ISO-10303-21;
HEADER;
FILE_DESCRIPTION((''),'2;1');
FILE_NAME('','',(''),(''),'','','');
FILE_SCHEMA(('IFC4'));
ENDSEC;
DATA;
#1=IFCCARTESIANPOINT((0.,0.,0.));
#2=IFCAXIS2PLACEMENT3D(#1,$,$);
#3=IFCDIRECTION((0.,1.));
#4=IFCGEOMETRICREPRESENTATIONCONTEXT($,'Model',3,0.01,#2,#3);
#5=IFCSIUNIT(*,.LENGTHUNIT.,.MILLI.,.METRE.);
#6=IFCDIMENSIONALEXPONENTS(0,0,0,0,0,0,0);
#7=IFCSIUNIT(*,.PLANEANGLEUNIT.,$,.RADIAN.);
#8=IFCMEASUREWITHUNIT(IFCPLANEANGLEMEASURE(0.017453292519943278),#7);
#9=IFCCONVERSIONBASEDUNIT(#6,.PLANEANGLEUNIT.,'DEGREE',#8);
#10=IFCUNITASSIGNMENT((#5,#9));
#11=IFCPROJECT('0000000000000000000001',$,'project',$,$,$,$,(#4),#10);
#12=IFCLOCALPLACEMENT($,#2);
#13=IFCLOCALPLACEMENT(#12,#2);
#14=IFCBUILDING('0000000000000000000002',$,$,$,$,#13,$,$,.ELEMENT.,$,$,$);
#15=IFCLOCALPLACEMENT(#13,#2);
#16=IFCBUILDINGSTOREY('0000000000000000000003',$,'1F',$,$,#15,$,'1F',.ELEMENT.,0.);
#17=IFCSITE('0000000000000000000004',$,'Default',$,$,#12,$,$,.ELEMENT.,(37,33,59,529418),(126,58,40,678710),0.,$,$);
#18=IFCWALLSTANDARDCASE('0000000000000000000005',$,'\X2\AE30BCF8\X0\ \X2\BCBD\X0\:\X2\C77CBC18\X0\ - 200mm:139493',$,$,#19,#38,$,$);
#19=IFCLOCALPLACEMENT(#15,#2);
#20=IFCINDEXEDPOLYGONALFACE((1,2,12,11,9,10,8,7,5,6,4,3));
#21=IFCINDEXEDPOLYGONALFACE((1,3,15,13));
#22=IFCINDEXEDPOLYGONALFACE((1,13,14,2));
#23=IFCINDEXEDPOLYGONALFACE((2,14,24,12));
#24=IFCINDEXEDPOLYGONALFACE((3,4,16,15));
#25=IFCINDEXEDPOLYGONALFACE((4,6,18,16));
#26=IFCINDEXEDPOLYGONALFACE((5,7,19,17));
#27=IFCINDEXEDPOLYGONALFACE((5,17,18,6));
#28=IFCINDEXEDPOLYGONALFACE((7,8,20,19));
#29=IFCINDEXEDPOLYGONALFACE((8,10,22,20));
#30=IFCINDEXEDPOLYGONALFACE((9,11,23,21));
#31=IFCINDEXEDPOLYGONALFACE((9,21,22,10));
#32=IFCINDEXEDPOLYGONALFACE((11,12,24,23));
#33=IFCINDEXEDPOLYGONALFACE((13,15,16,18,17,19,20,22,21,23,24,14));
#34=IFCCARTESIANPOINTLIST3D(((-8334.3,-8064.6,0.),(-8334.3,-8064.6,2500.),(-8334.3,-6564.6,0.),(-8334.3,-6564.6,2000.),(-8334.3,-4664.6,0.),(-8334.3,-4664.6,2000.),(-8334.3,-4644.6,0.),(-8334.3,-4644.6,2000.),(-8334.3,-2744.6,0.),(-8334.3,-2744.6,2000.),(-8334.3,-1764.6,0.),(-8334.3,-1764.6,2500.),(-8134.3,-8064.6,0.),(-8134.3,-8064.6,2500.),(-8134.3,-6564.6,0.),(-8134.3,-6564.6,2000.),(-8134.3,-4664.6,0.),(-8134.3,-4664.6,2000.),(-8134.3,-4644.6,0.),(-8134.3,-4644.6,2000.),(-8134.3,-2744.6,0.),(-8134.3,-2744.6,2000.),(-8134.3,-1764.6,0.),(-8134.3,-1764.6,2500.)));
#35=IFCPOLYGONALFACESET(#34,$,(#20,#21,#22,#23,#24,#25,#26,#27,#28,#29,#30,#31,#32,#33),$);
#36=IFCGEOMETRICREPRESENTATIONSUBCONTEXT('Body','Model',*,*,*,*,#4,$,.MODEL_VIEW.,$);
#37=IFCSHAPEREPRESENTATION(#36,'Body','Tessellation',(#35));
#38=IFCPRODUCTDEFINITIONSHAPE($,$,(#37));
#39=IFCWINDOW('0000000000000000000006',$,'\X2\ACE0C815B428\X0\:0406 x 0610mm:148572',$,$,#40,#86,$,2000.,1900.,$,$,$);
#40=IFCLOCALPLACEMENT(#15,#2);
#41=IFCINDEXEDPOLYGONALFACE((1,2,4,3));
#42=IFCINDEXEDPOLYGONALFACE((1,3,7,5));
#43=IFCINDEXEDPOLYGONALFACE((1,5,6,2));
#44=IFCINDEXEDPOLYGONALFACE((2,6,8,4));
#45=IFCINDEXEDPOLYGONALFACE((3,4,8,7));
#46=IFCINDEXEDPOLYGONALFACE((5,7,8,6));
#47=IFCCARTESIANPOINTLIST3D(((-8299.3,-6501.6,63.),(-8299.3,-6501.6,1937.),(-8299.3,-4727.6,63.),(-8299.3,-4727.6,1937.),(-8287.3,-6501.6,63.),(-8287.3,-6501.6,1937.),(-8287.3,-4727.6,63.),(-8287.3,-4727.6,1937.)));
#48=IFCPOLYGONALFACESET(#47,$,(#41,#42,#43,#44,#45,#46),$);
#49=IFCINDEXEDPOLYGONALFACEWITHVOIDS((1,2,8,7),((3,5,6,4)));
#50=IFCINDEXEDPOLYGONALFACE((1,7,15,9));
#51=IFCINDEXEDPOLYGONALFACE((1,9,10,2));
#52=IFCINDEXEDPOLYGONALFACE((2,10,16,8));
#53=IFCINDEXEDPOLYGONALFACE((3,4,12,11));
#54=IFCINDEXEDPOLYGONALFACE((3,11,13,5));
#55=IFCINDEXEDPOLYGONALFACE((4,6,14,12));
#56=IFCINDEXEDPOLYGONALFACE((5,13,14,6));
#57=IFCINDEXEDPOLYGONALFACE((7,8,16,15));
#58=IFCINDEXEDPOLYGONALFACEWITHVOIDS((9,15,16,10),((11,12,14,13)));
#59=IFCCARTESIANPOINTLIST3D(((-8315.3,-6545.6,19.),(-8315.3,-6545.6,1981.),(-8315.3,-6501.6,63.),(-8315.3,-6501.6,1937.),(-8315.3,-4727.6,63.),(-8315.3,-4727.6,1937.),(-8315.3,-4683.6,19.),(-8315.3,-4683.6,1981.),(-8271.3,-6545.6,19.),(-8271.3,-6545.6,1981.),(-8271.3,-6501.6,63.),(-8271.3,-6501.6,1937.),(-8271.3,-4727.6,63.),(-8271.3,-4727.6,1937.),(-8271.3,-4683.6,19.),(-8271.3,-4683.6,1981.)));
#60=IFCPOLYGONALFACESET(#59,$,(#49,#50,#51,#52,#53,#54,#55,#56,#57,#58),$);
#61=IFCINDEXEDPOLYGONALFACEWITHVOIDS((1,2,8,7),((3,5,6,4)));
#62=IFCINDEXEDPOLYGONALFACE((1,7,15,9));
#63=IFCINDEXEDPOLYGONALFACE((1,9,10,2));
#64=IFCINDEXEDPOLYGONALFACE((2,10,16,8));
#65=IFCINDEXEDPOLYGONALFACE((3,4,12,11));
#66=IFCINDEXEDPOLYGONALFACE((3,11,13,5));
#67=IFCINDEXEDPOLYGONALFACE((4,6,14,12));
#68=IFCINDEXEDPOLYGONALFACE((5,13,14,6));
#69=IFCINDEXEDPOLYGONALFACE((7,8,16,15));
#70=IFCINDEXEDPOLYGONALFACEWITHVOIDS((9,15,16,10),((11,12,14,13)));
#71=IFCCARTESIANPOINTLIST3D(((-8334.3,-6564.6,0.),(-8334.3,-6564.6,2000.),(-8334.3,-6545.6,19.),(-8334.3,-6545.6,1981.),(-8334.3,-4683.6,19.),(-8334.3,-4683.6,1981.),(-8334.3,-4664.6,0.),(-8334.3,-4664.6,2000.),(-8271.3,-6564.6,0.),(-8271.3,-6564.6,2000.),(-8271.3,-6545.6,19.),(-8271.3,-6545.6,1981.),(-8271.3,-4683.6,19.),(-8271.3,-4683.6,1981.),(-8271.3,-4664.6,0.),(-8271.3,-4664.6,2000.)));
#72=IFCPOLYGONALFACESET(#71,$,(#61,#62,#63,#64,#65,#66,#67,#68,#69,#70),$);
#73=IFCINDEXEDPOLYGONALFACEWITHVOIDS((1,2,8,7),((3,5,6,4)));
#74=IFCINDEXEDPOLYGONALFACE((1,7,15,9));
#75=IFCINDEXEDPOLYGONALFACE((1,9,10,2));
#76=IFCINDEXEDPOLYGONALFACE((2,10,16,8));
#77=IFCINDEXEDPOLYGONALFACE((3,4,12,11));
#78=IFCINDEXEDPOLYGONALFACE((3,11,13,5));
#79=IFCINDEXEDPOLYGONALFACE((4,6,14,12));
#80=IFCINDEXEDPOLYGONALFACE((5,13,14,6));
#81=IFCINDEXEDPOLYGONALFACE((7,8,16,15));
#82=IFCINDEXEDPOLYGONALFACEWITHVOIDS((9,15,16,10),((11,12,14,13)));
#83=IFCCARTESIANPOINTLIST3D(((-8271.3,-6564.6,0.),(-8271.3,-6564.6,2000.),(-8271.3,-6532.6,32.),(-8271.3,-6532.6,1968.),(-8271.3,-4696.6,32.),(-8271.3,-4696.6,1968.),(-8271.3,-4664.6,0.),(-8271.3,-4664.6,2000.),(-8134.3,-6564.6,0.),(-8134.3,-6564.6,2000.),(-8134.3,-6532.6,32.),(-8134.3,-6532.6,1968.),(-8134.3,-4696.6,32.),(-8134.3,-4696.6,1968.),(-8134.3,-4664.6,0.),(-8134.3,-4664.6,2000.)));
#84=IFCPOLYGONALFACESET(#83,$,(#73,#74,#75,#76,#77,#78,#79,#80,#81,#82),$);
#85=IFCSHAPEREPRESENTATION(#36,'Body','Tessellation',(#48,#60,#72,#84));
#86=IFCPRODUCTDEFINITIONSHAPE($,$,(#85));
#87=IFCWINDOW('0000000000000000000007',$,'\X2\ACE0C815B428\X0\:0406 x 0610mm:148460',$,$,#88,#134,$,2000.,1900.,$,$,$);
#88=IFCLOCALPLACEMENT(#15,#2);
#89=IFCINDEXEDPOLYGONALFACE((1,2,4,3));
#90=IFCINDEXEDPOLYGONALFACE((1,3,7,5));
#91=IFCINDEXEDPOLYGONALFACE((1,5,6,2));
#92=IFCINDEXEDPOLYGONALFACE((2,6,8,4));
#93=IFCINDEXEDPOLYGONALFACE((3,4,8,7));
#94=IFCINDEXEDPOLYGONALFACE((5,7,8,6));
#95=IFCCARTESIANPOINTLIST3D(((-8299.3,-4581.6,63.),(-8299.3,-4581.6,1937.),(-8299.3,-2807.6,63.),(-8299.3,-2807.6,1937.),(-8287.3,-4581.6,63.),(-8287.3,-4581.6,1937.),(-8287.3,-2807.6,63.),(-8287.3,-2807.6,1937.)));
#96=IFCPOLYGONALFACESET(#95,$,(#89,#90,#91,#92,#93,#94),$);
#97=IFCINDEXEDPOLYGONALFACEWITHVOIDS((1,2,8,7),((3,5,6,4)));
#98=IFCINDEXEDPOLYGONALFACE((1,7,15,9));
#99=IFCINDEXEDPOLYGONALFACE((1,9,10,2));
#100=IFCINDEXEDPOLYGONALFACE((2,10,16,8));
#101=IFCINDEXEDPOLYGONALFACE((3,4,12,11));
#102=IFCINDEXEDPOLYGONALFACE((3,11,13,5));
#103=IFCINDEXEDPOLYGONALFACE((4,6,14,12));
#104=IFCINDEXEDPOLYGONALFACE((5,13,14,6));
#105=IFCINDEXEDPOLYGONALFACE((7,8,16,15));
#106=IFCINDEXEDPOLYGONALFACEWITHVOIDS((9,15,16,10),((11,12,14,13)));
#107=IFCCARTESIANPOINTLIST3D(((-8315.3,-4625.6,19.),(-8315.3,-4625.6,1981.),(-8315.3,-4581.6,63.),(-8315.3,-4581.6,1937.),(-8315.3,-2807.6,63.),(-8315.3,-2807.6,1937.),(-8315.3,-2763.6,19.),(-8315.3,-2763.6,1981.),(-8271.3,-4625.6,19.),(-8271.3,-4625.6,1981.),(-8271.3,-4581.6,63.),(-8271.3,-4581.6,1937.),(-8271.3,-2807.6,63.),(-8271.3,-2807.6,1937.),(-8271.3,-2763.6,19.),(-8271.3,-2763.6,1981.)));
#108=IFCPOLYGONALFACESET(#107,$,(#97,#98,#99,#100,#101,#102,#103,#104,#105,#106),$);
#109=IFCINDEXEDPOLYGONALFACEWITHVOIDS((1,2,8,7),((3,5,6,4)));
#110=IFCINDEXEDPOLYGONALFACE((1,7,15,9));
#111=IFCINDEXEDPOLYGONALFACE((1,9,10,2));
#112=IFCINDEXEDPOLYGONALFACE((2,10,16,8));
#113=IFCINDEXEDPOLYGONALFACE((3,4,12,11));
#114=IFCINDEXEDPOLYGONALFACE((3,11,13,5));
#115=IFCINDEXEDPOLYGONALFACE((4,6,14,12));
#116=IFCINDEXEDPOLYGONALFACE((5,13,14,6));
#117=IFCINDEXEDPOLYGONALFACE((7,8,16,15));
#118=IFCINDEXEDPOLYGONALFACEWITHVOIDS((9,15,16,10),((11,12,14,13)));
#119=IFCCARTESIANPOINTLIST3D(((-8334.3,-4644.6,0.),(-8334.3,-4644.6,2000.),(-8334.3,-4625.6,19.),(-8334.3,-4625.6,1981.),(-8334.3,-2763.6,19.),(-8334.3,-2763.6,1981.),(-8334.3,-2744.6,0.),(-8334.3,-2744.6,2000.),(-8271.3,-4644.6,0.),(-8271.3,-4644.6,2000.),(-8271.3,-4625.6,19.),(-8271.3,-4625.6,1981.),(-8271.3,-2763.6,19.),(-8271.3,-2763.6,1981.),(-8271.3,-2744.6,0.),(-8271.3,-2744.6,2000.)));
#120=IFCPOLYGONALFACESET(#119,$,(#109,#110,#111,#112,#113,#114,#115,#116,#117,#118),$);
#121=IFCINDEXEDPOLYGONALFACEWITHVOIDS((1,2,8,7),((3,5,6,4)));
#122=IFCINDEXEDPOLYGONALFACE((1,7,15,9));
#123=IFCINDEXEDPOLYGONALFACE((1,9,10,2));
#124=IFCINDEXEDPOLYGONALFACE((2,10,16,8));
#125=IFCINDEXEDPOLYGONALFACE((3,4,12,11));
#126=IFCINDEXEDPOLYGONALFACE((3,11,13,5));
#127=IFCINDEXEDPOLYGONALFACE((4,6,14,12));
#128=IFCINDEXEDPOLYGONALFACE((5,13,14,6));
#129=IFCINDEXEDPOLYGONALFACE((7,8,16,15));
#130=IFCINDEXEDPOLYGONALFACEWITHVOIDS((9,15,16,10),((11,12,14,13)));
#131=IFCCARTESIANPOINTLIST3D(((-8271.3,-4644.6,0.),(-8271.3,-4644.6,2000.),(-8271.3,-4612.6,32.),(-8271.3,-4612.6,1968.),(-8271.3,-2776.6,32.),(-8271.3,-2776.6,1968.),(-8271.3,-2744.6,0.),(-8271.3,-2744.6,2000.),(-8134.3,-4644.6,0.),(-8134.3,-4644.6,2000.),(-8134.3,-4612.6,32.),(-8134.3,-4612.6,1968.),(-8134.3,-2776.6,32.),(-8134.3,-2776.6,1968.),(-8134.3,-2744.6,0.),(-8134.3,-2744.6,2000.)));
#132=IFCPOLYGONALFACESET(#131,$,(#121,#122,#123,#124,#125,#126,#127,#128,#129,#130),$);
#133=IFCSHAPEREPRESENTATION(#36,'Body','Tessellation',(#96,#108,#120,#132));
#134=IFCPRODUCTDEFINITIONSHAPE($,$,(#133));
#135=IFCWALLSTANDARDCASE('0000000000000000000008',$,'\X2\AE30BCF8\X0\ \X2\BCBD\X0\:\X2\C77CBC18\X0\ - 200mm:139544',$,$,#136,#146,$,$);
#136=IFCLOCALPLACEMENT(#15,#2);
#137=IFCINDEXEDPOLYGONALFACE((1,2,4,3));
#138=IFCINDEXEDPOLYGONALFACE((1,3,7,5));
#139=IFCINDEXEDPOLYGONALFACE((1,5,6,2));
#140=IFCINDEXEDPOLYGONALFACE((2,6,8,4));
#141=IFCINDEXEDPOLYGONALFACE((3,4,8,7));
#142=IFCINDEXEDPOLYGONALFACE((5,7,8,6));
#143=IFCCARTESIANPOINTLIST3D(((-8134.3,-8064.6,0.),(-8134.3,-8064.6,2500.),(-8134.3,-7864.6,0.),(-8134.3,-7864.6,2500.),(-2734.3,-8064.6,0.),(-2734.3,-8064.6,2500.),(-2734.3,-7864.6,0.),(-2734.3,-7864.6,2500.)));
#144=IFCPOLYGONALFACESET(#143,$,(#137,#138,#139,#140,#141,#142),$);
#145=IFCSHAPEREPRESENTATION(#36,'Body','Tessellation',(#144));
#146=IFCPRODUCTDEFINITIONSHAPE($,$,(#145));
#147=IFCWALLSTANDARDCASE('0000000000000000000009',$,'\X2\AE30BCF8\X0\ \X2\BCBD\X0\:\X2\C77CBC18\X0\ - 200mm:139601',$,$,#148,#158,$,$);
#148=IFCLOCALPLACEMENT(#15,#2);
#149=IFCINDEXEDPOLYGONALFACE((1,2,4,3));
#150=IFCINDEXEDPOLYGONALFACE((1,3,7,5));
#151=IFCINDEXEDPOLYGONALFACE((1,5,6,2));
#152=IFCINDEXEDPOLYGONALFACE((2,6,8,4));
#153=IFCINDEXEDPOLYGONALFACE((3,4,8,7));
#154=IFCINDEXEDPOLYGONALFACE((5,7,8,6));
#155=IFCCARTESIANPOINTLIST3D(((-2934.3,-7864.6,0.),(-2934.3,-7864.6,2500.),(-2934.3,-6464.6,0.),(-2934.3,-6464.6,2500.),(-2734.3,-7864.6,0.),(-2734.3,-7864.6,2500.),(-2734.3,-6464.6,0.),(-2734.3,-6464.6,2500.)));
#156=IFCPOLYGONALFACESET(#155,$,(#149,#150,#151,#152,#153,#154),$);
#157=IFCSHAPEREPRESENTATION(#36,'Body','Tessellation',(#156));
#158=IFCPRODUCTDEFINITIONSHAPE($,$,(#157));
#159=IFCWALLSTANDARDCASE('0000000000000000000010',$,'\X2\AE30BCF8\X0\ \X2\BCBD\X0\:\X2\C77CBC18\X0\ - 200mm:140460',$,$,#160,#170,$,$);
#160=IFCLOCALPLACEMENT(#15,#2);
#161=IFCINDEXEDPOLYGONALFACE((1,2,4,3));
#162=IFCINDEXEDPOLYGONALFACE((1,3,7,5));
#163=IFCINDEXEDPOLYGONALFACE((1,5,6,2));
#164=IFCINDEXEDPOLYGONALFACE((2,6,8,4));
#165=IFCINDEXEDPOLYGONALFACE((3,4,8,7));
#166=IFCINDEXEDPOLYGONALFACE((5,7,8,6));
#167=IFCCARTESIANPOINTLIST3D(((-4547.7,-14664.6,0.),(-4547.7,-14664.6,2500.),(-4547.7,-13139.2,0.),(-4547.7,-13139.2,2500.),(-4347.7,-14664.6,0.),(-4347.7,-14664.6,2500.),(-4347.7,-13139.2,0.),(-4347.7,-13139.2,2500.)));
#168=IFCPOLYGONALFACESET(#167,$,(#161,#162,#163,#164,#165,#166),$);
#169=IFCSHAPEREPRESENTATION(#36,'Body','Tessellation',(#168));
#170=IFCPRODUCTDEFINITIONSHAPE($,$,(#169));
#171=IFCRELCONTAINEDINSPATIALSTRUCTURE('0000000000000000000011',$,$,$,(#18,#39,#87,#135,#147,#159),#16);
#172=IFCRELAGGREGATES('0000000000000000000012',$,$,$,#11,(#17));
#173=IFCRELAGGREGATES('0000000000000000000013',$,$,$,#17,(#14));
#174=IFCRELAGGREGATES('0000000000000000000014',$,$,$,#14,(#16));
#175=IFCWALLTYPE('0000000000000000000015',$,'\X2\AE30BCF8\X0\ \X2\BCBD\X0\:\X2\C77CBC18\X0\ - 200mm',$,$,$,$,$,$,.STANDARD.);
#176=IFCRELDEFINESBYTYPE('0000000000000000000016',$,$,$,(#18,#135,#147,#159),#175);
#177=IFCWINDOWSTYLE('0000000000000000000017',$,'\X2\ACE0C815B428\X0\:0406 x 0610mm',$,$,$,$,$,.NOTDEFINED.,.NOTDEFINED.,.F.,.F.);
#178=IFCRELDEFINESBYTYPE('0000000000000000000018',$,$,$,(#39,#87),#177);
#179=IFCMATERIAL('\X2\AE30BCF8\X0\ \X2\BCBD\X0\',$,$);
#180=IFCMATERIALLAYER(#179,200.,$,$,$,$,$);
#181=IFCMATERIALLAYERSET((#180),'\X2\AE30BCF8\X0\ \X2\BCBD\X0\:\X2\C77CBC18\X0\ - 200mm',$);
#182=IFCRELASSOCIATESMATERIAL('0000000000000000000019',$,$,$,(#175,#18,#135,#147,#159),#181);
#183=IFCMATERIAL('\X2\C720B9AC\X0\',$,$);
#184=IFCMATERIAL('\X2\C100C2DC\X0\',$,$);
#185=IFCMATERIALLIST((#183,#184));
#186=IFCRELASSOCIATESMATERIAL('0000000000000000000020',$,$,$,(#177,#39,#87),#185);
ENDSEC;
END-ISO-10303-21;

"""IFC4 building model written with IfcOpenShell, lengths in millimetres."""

from ifc_helpers import new_model, entity, si_unit, converted_unit, direction, frame, frame_2d, origin, place, context, subcontext, project, spatial, polyline, rectangle, outline, extrude, source, transform, mapped, material, material_list, layer, layer_set, layer_usage, type_object, type_shapes, element, fill, save


model = new_model("IFC4")

# Units and contexts
model_context = context("Model", 3, precision=0.01, world=origin(), true_north=direction((0.0, 1.0)))
body_context = subcontext(model_context, "Body", "Model", "MODEL_VIEW")
ifc_project = project(units=[si_unit("LENGTHUNIT", "METRE", prefix="MILLI"), converted_unit("PLANEANGLEUNIT", "DEGREE", entity("IfcPlaneAngleMeasure", 0.017453292519943278), si_unit("PLANEANGLEUNIT", "RADIAN"), dimensions=[0, 0, 0, 0, 0, 0, 0])], contexts=[model_context])

# Site, building, storey
site_placement = place(None, origin())
site = spatial("IfcSite", under=ifc_project, at=site_placement, Name="Default", CompositionType="ELEMENT", RefLatitude=(37, 33, 59, 529418), RefLongitude=(126, 58, 40, 678710), RefElevation=0.0)
building_placement = place(site_placement, origin())
building = spatial("IfcBuilding", under=site, at=building_placement, CompositionType="ELEMENT")
storey_placement = place(building_placement, origin())
storey = spatial("IfcBuildingStorey", under=building, at=storey_placement, Name="1F", LongName="1F", CompositionType="ELEMENT", Elevation=0.0)

# Shared definitions
ifc_material_1 = material(Name="기본 벽")
ifc_layer_1 = layer(ifc_material_1, 200.0)
ifc_layer_set_1 = layer_set([ifc_layer_1], Name="기본 벽:일반 - 200mm")
wall_type = type_object("IfcWallType", Name="기본 벽:일반 - 200mm", PredefinedType="STANDARD", material=ifc_layer_set_1)
ifc_material_2 = material(Name="유리")
ifc_material_3 = material(Name="섀시")
ifc_material_list = material_list([ifc_material_2, ifc_material_3])
window_style = type_object("IfcWindowStyle", Name="고정됨:0406 x 0610mm", ConstructionType="NOTDEFINED", OperationType="NOTDEFINED", ParameterTakesPrecedence=False, Sizeable=False, material=ifc_material_list)
shared_shape = source(origin(), body_context, "Body", "SweptSolid", [
    extrude(rectangle(XDim=12.0, YDim=1774.0, at=frame_2d((0.0, 0.0), x_axis=(1.0, 0.0))), frame((950.0, 159.0, 63.0), z_axis=(0.0, 0.0, 1.0), x_axis=(0.0, -1.0, 0.0)), (0.0, 0.0, 1.0), 1874.0),
    extrude(outline(polyline([(-931.0, -981.0), (931.0, -981.0), (931.0, 981.0), (-931.0, 981.0), (-931.0, -981.0)]), holes=[polyline([(-887.0, -937.0), (-887.0, 937.0), (887.0, 937.0), (887.0, -937.0), (-887.0, -937.0)])]), frame((950.0, 137.0, 1000.0), z_axis=(0.0, 1.0, 0.0), x_axis=(1.0, 0.0, 0.0)), (0.0, 0.0, 1.0), 44.0),
    extrude(outline(polyline([(-950.0, -1000.0), (950.0, -1000.0), (950.0, 1000.0), (-950.0, 1000.0), (-950.0, -1000.0)]), holes=[polyline([(-931.0, -981.0), (-931.0, 981.0), (931.0, 981.0), (931.0, -981.0), (-931.0, -981.0)])]), frame((950.0, 137.0, 1000.0), z_axis=(0.0, 1.0, 0.0), x_axis=(1.0, 0.0, 0.0)), (0.0, 0.0, 1.0), 63.0),
    extrude(outline(polyline([(-950.0, -1000.0), (950.0, -1000.0), (950.0, 1000.0), (-950.0, 1000.0), (-950.0, -1000.0)]), holes=[polyline([(-918.0, -968.0), (-918.0, 968.0), (918.0, 968.0), (918.0, -968.0), (-918.0, -968.0)])]), frame((950.0, 0.0, 1000.0), z_axis=(0.0, 1.0, 0.0), x_axis=(1.0, 0.0, 0.0)), (0.0, 0.0, 1.0), 137.0),
])
type_shapes(window_style, [shared_shape])

# Wall, openings, windows
ifc_layer_usage_1 = layer_usage(ifc_layer_set_1, "AXIS2", "NEGATIVE", 100.0)
wall_1_placement = place(storey_placement, frame((-8234.3, -1764.6, 0.0), z_axis=(0.0, 0.0, 1.0), x_axis=(0.0, -1.0, 0.0)))
wall_1 = element("IfcWallStandardCase", 1, at=wall_1_placement, inside=storey, type_object=wall_type, material=ifc_layer_usage_1, Name="기본 벽:일반 - 200mm:139493", context=body_context, shape_type="SweptSolid", body=[
    extrude(rectangle(XDim=6300.0, YDim=200.0, at=frame_2d((3150.0, 0.0), x_axis=(-1.0, 0.0))), origin(), (0.0, 0.0, 1.0), 2500.0),
])
opening_1_placement = place(wall_1_placement, frame((4800.0, 100.0, 0.0)))
opening_1 = element("IfcOpeningElement", 2, at=opening_1_placement, cuts=wall_1, ObjectType="Opening", context=body_context, shape_type="SweptSolid", body=[
    extrude(rectangle(XDim=2000.0, YDim=1900.0, at=frame_2d((1000.0, 950.0), x_axis=(1.0, 0.0))), frame((0.0, 0.0, 0.0), z_axis=(0.0, -1.0, 0.0), x_axis=(0.0, 0.0, 1.0)), (0.0, 0.0, 1.0), 200.0),
])
opening_2_placement = place(wall_1_placement, frame((2880.0, 100.0, 0.0)))
opening_2 = element("IfcOpeningElement", 3, at=opening_2_placement, cuts=wall_1, ObjectType="Opening", context=body_context, shape_type="SweptSolid", body=[
    extrude(rectangle(XDim=2000.0, YDim=1900.0, at=frame_2d((1000.0, 950.0), x_axis=(1.0, 0.0))), frame((0.0, 0.0, 0.0), z_axis=(0.0, -1.0, 0.0), x_axis=(0.0, 0.0, 1.0)), (0.0, 0.0, 1.0), 200.0),
])
window_1_placement = place(opening_1_placement, frame((0.0, 0.0, 0.0), z_axis=(0.0, 0.0, 1.0), x_axis=(-1.0, 0.0, 0.0)))
window_1 = element("IfcWindow", 4, at=window_1_placement, inside=storey, type_object=window_style, material=ifc_material_list, Name="고정됨:0406 x 0610mm:148572", OverallHeight=2000.0, OverallWidth=1900.0, context=body_context, shape_type="MappedRepresentation", body=[
    mapped(shared_shape, transform((0.0, 0.0, 0.0), scale=1.0)),
])
fill(opening_1, window_1)
window_2_placement = place(opening_2_placement, frame((0.0, 0.0, 0.0), z_axis=(0.0, 0.0, 1.0), x_axis=(-1.0, 0.0, 0.0)))
window_2 = element("IfcWindow", 5, at=window_2_placement, inside=storey, type_object=window_style, material=ifc_material_list, Name="고정됨:0406 x 0610mm:148460", OverallHeight=2000.0, OverallWidth=1900.0, context=body_context, shape_type="MappedRepresentation", body=[
    mapped(shared_shape, transform((0.0, 0.0, 0.0), scale=1.0)),
])
fill(opening_2, window_2)

# Walls
ifc_layer_usage_2 = layer_usage(ifc_layer_set_1, "AXIS2", "NEGATIVE", 100.0)
wall_2_placement = place(storey_placement, frame((-8134.3, -7964.6, 0.0)))
element("IfcWallStandardCase", 6, at=wall_2_placement, inside=storey, type_object=wall_type, material=ifc_layer_usage_2, Name="기본 벽:일반 - 200mm:139544", context=body_context, shape_type="SweptSolid", body=[
    extrude(rectangle(XDim=5400.0, YDim=200.0, at=frame_2d((2700.0, 0.0), x_axis=(-1.0, 0.0))), origin(), (0.0, 0.0, 1.0), 2500.0),
])
ifc_layer_usage_3 = layer_usage(ifc_layer_set_1, "AXIS2", "NEGATIVE", 100.0)
wall_3_placement = place(storey_placement, frame((-2834.3, -7864.6, 0.0), z_axis=(0.0, 0.0, 1.0), x_axis=(0.0, 1.0, 0.0)))
element("IfcWallStandardCase", 7, at=wall_3_placement, inside=storey, type_object=wall_type, material=ifc_layer_usage_3, Name="기본 벽:일반 - 200mm:139601", context=body_context, shape_type="SweptSolid", body=[
    extrude(rectangle(XDim=1400.0, YDim=200.0, at=frame_2d((700.0, 0.0), x_axis=(-1.0, 0.0))), origin(), (0.0, 0.0, 1.0), 2500.0),
])
ifc_layer_usage_4 = layer_usage(ifc_layer_set_1, "AXIS2", "NEGATIVE", 100.0)
wall_4_placement = place(storey_placement, frame((-4447.7, -13139.2, 0.0), z_axis=(0.0, 0.0, 1.0), x_axis=(0.0, -1.0, 0.0)))
element("IfcWallStandardCase", 8, at=wall_4_placement, inside=storey, type_object=wall_type, material=ifc_layer_usage_4, Name="기본 벽:일반 - 200mm:140460", context=body_context, shape_type="SweptSolid", body=[
    extrude(rectangle(XDim=1525.5, YDim=200.0, at=frame_2d((762.7, 0.0), x_axis=(-1.0, 0.0))), origin(), (0.0, 0.0, 1.0), 2500.0),
])

save(model, "model.ifc")
